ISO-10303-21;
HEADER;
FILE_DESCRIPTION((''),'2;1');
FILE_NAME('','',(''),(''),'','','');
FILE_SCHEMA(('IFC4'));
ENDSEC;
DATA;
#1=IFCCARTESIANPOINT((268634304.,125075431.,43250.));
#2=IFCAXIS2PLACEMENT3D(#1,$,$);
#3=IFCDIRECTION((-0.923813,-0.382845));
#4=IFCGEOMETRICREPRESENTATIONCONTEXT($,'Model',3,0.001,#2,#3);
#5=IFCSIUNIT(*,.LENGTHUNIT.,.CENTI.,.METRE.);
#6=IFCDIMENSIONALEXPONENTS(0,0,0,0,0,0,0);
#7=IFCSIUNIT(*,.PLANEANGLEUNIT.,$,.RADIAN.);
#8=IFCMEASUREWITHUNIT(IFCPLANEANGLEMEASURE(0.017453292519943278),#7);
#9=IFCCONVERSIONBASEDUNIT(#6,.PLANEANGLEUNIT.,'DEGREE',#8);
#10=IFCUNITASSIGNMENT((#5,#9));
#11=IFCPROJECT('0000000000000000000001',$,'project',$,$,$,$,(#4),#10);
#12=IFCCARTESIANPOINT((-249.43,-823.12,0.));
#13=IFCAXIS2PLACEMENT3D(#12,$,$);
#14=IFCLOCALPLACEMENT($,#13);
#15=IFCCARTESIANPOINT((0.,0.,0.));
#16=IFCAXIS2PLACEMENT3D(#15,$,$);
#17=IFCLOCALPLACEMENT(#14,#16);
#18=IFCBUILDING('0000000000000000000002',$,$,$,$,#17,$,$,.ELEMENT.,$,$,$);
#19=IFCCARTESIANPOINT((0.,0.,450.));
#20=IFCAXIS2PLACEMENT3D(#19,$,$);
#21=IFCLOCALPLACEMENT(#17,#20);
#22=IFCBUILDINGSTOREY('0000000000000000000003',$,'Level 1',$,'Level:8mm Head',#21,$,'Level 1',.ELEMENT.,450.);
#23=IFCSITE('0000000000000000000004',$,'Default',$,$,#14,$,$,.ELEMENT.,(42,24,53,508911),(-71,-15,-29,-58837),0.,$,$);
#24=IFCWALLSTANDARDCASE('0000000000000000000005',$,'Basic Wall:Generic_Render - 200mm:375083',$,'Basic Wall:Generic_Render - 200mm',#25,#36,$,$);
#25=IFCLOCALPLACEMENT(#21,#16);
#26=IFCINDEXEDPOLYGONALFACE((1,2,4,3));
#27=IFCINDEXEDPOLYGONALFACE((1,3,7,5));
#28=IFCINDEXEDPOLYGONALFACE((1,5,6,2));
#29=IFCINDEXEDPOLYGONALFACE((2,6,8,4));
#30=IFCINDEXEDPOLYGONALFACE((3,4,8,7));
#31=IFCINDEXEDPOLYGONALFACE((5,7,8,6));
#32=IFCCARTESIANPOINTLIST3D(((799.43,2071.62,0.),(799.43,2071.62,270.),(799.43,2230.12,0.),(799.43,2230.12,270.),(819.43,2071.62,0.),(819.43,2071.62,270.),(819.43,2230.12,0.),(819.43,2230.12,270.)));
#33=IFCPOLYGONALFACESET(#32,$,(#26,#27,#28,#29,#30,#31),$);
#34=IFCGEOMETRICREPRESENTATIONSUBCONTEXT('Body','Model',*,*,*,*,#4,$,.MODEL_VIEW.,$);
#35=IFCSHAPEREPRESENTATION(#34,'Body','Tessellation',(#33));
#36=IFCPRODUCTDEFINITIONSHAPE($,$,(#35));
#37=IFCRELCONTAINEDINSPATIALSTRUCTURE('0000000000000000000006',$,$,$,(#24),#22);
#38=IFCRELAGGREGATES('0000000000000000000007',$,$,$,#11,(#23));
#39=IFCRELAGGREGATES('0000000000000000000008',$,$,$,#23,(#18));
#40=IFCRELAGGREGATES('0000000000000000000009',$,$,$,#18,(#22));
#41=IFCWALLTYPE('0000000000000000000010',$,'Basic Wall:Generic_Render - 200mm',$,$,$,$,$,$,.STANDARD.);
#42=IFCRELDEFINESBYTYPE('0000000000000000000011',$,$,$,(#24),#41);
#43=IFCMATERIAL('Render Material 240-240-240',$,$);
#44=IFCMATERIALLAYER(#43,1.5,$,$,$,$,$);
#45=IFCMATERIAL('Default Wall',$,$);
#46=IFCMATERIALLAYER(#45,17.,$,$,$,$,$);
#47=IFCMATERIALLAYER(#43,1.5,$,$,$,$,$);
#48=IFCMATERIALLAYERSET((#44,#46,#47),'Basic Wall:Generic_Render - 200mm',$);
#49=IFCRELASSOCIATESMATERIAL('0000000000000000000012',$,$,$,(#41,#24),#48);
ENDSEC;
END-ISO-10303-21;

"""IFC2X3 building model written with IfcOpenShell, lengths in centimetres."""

from ifc_helpers import new_model, entity, si_unit, converted_unit, direction, frame, frame_2d, origin, place, context, subcontext, project, spatial, rectangle, extrude, material, layer, layer_set, layer_usage, type_object, element, save


model = new_model("IFC2X3")

# Units and contexts
model_context = context("Model", 3, precision=0.001, world=frame((268634304.0, 125075431.0, 43250.0)), true_north=direction((-0.923813, -0.382845)))
body_context = subcontext(model_context, "Body", "Model", "MODEL_VIEW")
ifc_project = project(units=[si_unit("LENGTHUNIT", "METRE", prefix="CENTI"), converted_unit("PLANEANGLEUNIT", "DEGREE", entity("IfcPlaneAngleMeasure", 0.017453292519943278), si_unit("PLANEANGLEUNIT", "RADIAN"), dimensions=[0, 0, 0, 0, 0, 0, 0])], contexts=[model_context])

# Site, building, storey
site_placement = place(None, frame((-249.43, -823.12, 0.0)))
site = spatial("IfcSite", under=ifc_project, at=site_placement, Name="Default", CompositionType="ELEMENT", RefLatitude=(42, 24, 53, 508911), RefLongitude=(-71, -15, -29, -58837), RefElevation=0.0)
building_placement = place(site_placement, origin())
building = spatial("IfcBuilding", under=site, at=building_placement, CompositionType="ELEMENT")
storey_placement = place(building_placement, frame((0.0, 0.0, 450.0)))
storey = spatial("IfcBuildingStorey", under=building, at=storey_placement, Name="Level 1", ObjectType="Level:8mm Head", LongName="Level 1", CompositionType="ELEMENT", Elevation=450.0)

# Shared definitions
ifc_material_1 = material(Name="Render Material 240-240-240")

# Shared definitions
ifc_layer_1 = layer(ifc_material_1, 1.5)
ifc_material_2 = material(Name="Default Wall")
ifc_layer_2 = layer(ifc_material_2, 17.0)
ifc_layer_3 = layer(ifc_material_1, 1.5)
ifc_layer_set_1 = layer_set([ifc_layer_1, ifc_layer_2, ifc_layer_3], Name="Basic Wall:Generic_Render - 200mm")
wall_type_1 = type_object("IfcWallType", Name="Basic Wall:Generic_Render - 200mm", PredefinedType="STANDARD", material=ifc_layer_set_1)

# Wall
ifc_layer_usage_1 = layer_usage(ifc_layer_set_1, "AXIS2", "NEGATIVE", 10.0)
wall_1_placement = place(storey_placement, frame((809.43, 2071.62, 0.0), z_axis=(0.0, 0.0, 1.0), x_axis=(0.0, 1.0, 0.0)))
element("IfcWallStandardCase", 1, at=wall_1_placement, inside=storey, type_object=wall_type_1, material=ifc_layer_usage_1, Name="Basic Wall:Generic_Render - 200mm:375083", ObjectType="Basic Wall:Generic_Render - 200mm", context=body_context, shape_type="SweptSolid", body=[
    extrude(rectangle(XDim=158.5, YDim=20.0, at=frame_2d((79.25, 0.0), x_axis=(-1.0, 0.0))), origin(), (0.0, 0.0, 1.0), 270.0),
])

save(model, "model.ifc")
